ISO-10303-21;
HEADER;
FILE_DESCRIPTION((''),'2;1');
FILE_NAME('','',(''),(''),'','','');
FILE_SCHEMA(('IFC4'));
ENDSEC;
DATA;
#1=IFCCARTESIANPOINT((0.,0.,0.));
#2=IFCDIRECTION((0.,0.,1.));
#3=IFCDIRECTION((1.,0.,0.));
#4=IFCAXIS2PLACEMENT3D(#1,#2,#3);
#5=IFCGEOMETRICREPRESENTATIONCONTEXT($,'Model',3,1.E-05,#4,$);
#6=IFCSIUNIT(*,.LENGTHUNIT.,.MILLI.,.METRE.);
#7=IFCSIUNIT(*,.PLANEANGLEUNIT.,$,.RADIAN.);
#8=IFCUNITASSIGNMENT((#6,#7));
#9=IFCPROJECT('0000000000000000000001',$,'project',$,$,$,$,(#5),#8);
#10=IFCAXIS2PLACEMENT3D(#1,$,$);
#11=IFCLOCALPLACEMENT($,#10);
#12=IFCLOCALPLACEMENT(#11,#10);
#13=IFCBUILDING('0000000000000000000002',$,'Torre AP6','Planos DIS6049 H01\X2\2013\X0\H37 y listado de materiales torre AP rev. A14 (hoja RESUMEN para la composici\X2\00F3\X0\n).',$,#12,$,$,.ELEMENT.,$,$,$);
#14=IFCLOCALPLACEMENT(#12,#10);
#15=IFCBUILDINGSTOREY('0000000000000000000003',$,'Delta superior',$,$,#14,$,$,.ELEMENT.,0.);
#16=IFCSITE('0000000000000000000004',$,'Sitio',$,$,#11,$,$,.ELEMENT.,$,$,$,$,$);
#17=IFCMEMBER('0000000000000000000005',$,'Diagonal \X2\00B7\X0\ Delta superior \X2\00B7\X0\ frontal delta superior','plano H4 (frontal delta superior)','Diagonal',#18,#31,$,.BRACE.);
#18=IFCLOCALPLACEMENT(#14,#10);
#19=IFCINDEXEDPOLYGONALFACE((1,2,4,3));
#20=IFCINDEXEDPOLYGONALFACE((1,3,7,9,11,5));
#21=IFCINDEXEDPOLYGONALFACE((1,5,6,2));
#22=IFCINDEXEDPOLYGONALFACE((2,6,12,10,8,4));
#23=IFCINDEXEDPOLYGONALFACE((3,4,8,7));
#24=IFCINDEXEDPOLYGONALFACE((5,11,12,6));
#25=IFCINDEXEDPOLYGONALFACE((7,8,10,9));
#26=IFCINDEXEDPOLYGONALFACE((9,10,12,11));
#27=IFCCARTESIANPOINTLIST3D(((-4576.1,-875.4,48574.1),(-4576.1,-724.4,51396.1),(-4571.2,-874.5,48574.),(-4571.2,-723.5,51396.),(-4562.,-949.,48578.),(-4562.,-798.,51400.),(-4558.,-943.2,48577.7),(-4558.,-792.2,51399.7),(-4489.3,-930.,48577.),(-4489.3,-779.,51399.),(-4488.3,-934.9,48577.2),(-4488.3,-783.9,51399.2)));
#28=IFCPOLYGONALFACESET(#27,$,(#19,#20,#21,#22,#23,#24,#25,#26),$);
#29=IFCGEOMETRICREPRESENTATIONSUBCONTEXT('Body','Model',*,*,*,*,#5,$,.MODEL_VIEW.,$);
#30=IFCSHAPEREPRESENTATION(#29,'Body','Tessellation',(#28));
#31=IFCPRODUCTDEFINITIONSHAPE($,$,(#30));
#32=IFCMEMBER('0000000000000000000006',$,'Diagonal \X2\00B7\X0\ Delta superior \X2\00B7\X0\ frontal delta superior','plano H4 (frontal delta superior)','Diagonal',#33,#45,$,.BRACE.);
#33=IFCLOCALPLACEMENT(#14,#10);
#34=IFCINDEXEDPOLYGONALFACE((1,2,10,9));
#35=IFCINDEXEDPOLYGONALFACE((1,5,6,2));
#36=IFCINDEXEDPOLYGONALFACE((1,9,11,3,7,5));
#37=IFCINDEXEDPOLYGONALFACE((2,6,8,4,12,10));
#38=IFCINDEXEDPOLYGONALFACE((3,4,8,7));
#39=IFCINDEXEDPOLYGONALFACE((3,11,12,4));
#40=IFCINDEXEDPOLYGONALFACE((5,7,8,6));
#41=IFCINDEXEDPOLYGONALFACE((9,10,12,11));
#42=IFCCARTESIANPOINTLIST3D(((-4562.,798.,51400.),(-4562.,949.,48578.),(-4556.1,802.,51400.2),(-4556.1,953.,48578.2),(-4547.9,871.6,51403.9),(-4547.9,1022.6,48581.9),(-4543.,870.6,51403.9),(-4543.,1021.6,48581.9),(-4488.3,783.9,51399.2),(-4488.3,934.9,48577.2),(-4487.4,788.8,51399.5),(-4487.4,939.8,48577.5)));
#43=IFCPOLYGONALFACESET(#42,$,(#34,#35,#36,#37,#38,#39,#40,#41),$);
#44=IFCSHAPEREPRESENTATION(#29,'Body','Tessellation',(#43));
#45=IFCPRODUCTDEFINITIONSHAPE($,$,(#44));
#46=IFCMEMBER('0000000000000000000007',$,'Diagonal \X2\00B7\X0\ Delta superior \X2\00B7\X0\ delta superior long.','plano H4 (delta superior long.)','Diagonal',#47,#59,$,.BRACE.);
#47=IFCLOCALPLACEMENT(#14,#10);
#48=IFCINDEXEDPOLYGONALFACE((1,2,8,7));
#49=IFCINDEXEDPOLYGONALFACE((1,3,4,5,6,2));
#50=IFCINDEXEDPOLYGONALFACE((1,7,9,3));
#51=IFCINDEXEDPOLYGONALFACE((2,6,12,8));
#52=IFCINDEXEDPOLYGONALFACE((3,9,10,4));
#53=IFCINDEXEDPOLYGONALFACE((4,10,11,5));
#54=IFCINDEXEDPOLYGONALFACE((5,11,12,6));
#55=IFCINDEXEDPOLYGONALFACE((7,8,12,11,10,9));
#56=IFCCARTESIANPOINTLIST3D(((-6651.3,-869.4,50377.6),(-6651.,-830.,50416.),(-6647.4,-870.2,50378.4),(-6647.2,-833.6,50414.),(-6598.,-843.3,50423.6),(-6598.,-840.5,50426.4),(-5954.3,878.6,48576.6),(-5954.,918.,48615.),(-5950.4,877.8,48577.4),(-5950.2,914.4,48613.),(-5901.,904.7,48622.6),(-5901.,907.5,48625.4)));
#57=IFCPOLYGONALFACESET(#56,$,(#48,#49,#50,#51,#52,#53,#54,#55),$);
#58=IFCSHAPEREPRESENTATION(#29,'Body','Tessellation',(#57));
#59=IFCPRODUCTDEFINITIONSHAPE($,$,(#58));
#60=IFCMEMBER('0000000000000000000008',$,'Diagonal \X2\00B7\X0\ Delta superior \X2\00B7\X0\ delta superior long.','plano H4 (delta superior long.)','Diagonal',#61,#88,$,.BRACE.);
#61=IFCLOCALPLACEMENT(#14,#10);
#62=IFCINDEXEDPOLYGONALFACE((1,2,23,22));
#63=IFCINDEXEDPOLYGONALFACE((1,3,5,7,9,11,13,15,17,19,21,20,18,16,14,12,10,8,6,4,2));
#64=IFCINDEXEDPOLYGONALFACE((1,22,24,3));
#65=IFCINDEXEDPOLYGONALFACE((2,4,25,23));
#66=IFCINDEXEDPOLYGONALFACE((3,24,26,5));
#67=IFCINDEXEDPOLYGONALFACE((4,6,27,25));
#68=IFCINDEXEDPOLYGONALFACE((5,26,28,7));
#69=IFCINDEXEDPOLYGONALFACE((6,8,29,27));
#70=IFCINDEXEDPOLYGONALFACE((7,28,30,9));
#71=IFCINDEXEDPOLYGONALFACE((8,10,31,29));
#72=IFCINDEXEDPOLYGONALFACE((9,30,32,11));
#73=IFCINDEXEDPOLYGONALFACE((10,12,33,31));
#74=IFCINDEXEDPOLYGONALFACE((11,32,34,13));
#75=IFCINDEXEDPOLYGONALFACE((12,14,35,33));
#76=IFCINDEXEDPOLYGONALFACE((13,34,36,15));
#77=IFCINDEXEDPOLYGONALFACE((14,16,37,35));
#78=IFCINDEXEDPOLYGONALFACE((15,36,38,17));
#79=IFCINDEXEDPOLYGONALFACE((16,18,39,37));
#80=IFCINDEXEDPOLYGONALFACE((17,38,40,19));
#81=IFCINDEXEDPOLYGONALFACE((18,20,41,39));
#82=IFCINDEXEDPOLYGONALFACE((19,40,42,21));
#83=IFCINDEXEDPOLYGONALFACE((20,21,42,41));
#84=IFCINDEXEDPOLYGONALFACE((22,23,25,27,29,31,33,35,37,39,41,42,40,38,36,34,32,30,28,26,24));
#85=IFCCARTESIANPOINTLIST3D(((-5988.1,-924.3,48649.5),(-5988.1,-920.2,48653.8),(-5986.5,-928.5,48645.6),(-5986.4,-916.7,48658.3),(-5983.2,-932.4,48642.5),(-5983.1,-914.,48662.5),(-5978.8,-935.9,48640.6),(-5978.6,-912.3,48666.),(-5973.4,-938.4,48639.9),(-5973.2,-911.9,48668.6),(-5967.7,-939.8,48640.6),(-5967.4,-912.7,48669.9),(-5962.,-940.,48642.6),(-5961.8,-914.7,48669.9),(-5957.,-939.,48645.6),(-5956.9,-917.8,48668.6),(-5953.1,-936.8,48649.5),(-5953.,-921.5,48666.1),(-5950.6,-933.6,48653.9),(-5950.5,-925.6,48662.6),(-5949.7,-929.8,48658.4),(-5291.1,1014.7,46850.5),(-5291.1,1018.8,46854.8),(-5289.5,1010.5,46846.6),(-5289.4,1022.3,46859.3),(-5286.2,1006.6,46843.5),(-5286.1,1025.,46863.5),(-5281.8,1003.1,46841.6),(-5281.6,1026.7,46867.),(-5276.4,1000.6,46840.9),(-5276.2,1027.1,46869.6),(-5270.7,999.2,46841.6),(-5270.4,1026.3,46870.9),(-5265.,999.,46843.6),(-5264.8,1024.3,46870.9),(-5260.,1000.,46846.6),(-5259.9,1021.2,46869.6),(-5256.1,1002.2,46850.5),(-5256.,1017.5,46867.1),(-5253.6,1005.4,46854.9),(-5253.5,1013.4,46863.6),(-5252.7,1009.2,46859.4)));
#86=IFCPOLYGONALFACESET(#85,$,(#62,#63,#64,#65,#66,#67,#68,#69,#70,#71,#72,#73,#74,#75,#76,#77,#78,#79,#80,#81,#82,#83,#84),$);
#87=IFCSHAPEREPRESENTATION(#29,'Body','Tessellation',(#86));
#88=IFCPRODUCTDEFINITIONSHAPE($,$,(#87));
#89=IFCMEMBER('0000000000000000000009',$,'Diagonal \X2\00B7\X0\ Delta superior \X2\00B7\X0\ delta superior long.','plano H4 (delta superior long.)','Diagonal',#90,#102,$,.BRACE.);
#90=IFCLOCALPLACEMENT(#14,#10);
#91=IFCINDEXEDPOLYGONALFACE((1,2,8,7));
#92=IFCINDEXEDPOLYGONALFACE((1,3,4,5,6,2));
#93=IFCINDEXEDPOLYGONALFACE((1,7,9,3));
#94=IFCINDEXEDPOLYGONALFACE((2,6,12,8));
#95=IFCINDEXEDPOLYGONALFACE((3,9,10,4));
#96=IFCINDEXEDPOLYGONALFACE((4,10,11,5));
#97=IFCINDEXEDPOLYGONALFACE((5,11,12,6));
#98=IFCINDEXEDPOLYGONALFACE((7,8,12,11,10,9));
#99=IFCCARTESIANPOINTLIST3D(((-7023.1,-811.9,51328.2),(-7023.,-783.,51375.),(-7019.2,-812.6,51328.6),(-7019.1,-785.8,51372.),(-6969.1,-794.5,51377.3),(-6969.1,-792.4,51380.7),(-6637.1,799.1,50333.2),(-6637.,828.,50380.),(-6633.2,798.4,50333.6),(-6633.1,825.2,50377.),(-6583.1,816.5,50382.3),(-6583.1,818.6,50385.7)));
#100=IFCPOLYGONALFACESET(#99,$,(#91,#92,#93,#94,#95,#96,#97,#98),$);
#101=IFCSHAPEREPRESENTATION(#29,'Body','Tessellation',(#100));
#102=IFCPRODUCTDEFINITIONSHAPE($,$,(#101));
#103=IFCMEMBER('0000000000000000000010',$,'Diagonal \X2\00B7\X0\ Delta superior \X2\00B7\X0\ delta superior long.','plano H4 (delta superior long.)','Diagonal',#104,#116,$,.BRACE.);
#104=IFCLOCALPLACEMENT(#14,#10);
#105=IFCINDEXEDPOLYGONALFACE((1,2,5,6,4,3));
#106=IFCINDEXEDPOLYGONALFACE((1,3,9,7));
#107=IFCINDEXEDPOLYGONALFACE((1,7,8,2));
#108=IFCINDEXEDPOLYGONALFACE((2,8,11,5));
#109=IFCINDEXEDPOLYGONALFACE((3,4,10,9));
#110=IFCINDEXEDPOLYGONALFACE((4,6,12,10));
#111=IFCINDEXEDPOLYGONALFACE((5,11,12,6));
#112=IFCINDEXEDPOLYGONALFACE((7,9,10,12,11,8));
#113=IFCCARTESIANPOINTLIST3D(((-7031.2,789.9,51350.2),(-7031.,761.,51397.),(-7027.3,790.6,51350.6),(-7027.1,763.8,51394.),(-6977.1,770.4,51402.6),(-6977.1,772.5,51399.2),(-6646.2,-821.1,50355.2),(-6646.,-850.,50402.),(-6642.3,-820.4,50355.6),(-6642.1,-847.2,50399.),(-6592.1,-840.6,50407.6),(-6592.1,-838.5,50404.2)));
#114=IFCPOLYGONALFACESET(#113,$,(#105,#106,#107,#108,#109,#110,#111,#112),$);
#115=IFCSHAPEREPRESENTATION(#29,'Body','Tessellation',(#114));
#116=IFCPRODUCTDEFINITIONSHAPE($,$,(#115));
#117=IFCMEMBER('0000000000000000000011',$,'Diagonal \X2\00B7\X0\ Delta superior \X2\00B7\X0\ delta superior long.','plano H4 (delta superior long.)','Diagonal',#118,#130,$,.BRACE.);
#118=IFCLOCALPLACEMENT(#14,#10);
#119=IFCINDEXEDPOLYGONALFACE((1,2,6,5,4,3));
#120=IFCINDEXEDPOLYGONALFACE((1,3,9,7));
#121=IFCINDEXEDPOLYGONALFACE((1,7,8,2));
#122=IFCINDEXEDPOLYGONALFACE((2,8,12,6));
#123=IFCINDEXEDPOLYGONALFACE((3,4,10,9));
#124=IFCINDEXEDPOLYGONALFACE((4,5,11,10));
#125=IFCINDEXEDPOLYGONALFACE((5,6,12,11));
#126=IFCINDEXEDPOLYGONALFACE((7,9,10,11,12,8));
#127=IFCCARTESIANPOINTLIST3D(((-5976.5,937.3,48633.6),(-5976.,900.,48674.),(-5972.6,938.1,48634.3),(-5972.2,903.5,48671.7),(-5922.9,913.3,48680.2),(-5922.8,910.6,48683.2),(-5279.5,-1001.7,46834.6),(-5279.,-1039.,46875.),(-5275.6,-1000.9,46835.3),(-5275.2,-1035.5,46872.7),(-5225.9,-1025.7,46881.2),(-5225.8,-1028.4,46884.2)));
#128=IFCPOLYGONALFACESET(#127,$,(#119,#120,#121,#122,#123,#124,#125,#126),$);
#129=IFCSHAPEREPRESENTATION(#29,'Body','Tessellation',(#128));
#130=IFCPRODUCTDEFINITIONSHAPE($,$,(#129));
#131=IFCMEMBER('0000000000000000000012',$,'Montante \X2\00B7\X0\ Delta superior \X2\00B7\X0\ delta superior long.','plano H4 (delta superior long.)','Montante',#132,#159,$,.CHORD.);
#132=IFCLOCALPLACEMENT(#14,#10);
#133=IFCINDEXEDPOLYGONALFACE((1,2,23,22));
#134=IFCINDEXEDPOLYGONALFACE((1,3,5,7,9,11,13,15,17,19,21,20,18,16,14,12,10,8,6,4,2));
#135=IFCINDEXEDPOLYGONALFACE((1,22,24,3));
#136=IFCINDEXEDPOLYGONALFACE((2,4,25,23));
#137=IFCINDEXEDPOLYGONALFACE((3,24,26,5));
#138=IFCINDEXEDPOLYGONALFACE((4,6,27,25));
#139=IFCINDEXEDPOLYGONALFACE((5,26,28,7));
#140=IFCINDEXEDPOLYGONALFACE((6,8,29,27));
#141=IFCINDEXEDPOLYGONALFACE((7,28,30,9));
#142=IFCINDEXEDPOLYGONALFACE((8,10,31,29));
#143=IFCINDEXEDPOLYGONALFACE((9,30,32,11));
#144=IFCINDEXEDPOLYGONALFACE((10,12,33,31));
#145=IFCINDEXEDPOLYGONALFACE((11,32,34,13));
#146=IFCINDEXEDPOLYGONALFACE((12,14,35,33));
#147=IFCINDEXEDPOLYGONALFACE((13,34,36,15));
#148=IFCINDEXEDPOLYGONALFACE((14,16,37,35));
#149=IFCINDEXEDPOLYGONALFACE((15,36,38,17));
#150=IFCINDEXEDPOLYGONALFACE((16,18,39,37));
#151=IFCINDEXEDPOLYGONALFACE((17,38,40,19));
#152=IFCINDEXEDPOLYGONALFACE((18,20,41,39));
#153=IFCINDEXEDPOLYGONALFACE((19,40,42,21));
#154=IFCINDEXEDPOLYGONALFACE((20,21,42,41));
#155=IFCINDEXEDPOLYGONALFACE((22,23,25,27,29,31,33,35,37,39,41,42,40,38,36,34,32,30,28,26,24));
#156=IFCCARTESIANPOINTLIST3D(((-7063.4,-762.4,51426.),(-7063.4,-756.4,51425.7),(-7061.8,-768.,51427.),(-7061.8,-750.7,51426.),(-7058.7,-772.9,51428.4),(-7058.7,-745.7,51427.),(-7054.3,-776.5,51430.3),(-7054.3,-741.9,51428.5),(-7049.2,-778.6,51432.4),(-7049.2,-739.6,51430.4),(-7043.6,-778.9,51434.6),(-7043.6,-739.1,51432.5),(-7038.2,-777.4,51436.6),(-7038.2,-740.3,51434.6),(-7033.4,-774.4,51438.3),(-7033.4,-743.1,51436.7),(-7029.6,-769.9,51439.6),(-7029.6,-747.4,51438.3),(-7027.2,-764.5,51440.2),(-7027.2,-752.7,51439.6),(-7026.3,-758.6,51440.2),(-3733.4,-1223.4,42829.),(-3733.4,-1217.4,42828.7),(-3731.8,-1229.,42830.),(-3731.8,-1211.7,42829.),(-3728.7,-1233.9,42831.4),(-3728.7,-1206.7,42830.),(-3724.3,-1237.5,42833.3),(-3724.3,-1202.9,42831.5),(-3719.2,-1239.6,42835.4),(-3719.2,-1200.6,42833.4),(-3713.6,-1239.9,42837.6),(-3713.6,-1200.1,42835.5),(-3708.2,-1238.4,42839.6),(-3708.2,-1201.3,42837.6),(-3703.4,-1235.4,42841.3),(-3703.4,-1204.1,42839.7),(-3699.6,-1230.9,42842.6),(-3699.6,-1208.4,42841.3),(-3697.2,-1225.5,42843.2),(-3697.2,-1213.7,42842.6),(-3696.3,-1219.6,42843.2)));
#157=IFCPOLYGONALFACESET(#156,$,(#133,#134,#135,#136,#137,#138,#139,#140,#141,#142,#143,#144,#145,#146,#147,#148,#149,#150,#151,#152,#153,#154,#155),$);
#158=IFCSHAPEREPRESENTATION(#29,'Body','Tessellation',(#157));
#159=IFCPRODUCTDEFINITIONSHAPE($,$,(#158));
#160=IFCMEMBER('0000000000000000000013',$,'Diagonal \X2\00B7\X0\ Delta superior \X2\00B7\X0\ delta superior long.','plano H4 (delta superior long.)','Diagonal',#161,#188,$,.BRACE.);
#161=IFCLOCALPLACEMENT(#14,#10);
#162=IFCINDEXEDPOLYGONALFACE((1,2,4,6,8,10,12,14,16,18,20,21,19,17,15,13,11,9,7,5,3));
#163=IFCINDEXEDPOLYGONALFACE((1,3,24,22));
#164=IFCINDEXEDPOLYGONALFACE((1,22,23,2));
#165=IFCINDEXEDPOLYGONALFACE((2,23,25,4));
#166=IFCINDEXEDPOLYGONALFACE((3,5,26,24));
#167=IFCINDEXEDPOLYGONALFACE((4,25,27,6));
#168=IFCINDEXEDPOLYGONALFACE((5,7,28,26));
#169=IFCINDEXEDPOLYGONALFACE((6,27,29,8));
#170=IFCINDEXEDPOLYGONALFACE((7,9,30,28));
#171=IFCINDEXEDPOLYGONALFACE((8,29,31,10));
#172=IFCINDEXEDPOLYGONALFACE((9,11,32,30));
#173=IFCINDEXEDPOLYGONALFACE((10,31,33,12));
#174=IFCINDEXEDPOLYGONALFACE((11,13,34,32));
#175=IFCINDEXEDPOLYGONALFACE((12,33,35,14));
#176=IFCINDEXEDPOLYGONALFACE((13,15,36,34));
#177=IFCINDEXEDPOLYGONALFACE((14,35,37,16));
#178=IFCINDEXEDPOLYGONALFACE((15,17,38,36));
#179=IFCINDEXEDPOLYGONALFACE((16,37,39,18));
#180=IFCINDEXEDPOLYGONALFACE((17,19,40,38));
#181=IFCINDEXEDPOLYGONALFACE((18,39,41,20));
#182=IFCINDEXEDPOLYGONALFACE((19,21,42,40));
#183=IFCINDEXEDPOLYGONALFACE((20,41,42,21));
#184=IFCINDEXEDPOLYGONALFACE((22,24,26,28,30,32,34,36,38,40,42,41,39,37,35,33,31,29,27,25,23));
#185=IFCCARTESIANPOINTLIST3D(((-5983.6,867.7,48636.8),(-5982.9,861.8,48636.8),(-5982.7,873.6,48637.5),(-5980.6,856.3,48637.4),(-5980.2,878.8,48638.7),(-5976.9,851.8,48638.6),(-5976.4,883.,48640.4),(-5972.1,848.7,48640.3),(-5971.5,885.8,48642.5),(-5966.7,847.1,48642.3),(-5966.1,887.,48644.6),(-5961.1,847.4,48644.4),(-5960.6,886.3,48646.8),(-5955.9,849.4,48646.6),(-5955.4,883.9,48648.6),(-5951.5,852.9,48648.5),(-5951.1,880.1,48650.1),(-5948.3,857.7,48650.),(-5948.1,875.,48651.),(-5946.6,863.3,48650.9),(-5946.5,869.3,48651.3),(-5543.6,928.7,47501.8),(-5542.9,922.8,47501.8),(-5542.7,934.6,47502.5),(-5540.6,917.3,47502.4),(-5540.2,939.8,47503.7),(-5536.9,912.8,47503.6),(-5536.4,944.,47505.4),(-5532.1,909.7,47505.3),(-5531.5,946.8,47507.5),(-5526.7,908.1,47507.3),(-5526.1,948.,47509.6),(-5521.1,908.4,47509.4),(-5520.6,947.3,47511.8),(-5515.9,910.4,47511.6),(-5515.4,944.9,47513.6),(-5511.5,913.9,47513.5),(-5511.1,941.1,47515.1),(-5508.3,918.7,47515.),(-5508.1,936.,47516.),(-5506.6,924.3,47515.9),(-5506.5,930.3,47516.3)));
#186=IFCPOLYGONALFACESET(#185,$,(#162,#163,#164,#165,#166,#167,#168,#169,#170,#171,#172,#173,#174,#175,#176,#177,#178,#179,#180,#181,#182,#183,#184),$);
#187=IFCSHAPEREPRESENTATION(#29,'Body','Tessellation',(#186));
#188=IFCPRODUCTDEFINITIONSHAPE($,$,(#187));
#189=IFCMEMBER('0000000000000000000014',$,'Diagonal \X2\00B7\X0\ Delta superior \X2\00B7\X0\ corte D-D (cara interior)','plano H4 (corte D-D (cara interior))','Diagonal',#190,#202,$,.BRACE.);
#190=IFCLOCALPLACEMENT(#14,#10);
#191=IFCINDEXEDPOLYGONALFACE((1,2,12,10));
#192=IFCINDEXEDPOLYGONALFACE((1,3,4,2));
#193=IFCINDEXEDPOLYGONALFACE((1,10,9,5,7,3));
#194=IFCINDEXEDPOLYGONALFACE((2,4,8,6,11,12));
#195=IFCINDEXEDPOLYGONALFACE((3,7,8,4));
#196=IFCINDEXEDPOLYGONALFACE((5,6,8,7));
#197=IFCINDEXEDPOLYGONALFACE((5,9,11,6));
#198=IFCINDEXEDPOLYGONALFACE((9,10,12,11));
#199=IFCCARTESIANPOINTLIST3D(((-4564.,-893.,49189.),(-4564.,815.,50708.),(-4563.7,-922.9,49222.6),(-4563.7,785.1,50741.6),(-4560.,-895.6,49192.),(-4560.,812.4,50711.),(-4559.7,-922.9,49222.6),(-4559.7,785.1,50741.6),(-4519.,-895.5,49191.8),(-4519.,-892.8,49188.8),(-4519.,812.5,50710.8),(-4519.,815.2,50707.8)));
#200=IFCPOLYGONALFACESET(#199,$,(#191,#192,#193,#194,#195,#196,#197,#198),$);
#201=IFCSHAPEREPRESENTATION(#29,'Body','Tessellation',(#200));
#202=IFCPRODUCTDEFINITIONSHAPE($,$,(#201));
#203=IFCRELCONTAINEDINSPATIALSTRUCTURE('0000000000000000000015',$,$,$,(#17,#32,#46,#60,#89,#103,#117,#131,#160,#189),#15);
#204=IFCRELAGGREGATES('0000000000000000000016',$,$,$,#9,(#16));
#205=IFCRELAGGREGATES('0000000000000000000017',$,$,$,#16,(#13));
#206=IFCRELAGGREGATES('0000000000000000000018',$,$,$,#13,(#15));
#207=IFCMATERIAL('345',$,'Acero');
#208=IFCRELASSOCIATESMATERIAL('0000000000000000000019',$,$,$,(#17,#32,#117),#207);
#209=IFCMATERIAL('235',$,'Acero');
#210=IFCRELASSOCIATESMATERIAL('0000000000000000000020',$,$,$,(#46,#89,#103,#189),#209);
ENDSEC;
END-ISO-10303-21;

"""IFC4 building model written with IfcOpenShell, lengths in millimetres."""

from ifc_helpers import new_model, si_unit, frame, frame_2d, origin, origin_with_axes, place, context, subcontext, project, spatial, circle, l_section, extrude, material, element, save


model = new_model("IFC4")

# Units and contexts
model_context = context("Model", 3, precision=1e-05, world=origin_with_axes())
body_context = subcontext(model_context, "Body", "Model", "MODEL_VIEW")
ifc_project = project(units=[si_unit("LENGTHUNIT", "METRE", prefix="MILLI"), si_unit("PLANEANGLEUNIT", "RADIAN")], contexts=[model_context])

# Site, building, storey
site_placement = place(None, origin())
site = spatial("IfcSite", under=ifc_project, at=site_placement, Name="Sitio", CompositionType="ELEMENT")
building_placement = place(site_placement, origin())
building = spatial("IfcBuilding", under=site, at=building_placement, Name="Torre AP6", Description="Planos DIS6049 H01–H37 y listado de materiales torre AP rev. A14 (hoja RESUMEN para la composición).", CompositionType="ELEMENT")
storey_placement = place(building_placement, origin())
storey = spatial("IfcBuildingStorey", under=building, at=storey_placement, Name="Delta superior", CompositionType="ELEMENT", Elevation=0.0)

# Members
ifc_material_1 = material(Name="235", Category="Acero")
ifc_material_2 = material(Name="345", Category="Acero")
for number, where, z_axis, x_axis, name in (
    (1, (-4562.0, -949.0, 48578.0), (0.0, 0.053432, 0.998572), (0.982208, 0.187529, -0.010034), "Diagonal · Delta superior · frontal delta superior"),
    (2, (-4562.0, 949.0, 48578.0), (0.0, -0.053432, 0.998572), (0.982208, -0.187529, -0.010034), "Diagonal · Delta superior · frontal delta superior"),
):
    element("IfcMember", number, at=place(storey_placement, frame(where, z_axis=z_axis, x_axis=x_axis)), inside=storey, material=ifc_material_2, Name=name, Description="plano H4 (frontal delta superior)", ObjectType="Diagonal", PredefinedType="BRACE", context=body_context, shape_type="SweptSolid", body=[
        extrude(l_section(Depth=75.0, Width=75.0, Thickness=5.0, at=frame_2d((37.5, 37.5))), None, (0.0, 0.0, 1.0), 2826.0),
    ])
member_1_placement = place(storey_placement, frame((-6651.0, -830.0, 50416.0), z_axis=(0.267584, 0.671072, -0.691419), x_axis=(0.963521, -0.190088, 0.188396)))
element("IfcMember", 3, at=member_1_placement, inside=storey, material=ifc_material_1, Name="Diagonal · Delta superior · delta superior long.", Description="plano H4 (delta superior long.)", ObjectType="Diagonal", PredefinedType="BRACE", context=body_context, shape_type="SweptSolid", body=[
    extrude(l_section(Depth=55.0, Width=55.0, Thickness=4.0, at=frame_2d((27.5, 27.5))), None, (0.0, 0.0, 1.0), 2604.8),
])
member_2_placement = place(storey_placement, frame((-5969.0, -926.0, 48655.0), z_axis=(0.254816, 0.708877, -0.657695), x_axis=(0.966975, -0.190493, 0.169325)))
element("IfcMember", 4, at=member_2_placement, inside=storey, Name="Diagonal · Delta superior · delta superior long.", Description="plano H4 (delta superior long.)", ObjectType="Diagonal", PredefinedType="BRACE", context=body_context, shape_type="SweptSolid", body=[
    extrude(circle(Radius=20.0), None, (0.0, 0.0, 1.0), 2735.3),
])
member_3_placement = place(storey_placement, frame((-7023.0, -783.0, 51375.0), z_axis=(0.199747, 0.833659, -0.514892), x_axis=(0.979846, -0.170873, 0.103461)))
element("IfcMember", 5, at=member_3_placement, inside=storey, material=ifc_material_1, Name="Diagonal · Delta superior · delta superior long.", Description="plano H4 (delta superior long.)", ObjectType="Diagonal", PredefinedType="BRACE", context=body_context, shape_type="SweptSolid", body=[
    extrude(l_section(Depth=55.0, Width=55.0, Thickness=4.0, at=frame_2d((27.5, 27.5))), None, (0.0, 0.0, 1.0), 1932.4),
])
member_4_placement = place(storey_placement, frame((-6646.0, -850.0, 50402.0), z_axis=(-0.19925, 0.833745, 0.514945), x_axis=(0.979943, 0.171353, 0.101736)))
element("IfcMember", 6, at=member_4_placement, inside=storey, material=ifc_material_1, Name="Diagonal · Delta superior · delta superior long.", Description="plano H4 (delta superior long.)", ObjectType="Diagonal", PredefinedType="BRACE", context=body_context, shape_type="SweptSolid", body=[
    extrude(l_section(Depth=55.0, Width=55.0, Thickness=4.0, at=frame_2d((27.5, 27.5))), None, (0.0, 0.0, 1.0), 1932.2),
])
member_5_placement = place(storey_placement, frame((-5279.0, -1039.0, 46875.0), z_axis=(-0.254816, 0.708877, 0.657695), x_axis=(0.966953, 0.192686, 0.166953)))
element("IfcMember", 7, at=member_5_placement, inside=storey, material=ifc_material_2, Name="Diagonal · Delta superior · delta superior long.", Description="plano H4 (delta superior long.)", ObjectType="Diagonal", PredefinedType="BRACE", context=body_context, shape_type="SweptSolid", body=[
    extrude(l_section(Depth=55.0, Width=55.0, Thickness=4.0, at=frame_2d((27.5, 27.5))), None, (0.0, 0.0, 1.0), 2735.3),
])
for number, where, z_axis, x_axis, name in (
    (8, (-3715.0, -1220.0, 42836.0), (-0.360744, 0.049941, 0.931327), (0.932665, 0.019317, 0.360227), "Montante · Delta superior · delta superior long."),
):
    element("IfcMember", number, at=place(storey_placement, frame(where, z_axis=z_axis, x_axis=x_axis)), inside=storey, Name=name, Description="plano H4 (delta superior long.)", ObjectType="Montante", PredefinedType="CHORD", context=body_context, shape_type="SweptSolid", body=[
        extrude(circle(Radius=20.0), None, (0.0, 0.0, 1.0), 9230.9),
    ])
member_6_placement = place(storey_placement, frame((-5525.0, 928.0, 47509.0), z_axis=(-0.361002, -0.050048, 0.931221), x_axis=(0.919866, -0.183339, 0.346747)))
element("IfcMember", 9, at=member_6_placement, inside=storey, Name="Diagonal · Delta superior · delta superior long.", Description="plano H4 (delta superior long.)", ObjectType="Diagonal", PredefinedType="BRACE", context=body_context, shape_type="SweptSolid", body=[
    extrude(circle(Radius=20.0), None, (0.0, 0.0, 1.0), 1218.8),
])
member_7_placement = place(storey_placement, frame((-4564.0, 815.0, 50708.0), z_axis=(0.0, -0.74724, -0.664554), x_axis=(0.999984, 0.003774, -0.004243)))
element("IfcMember", 10, at=member_7_placement, inside=storey, material=ifc_material_1, Name="Diagonal · Delta superior · corte D-D (cara interior)", Description="plano H4 (corte D-D (cara interior))", ObjectType="Diagonal", PredefinedType="BRACE", context=body_context, shape_type="SweptSolid", body=[
    extrude(l_section(Depth=45.0, Width=45.0, Thickness=4.0, at=frame_2d((22.5, 22.5))), None, (0.0, 0.0, 1.0), 2285.7),
])

save(model, "model.ifc")
